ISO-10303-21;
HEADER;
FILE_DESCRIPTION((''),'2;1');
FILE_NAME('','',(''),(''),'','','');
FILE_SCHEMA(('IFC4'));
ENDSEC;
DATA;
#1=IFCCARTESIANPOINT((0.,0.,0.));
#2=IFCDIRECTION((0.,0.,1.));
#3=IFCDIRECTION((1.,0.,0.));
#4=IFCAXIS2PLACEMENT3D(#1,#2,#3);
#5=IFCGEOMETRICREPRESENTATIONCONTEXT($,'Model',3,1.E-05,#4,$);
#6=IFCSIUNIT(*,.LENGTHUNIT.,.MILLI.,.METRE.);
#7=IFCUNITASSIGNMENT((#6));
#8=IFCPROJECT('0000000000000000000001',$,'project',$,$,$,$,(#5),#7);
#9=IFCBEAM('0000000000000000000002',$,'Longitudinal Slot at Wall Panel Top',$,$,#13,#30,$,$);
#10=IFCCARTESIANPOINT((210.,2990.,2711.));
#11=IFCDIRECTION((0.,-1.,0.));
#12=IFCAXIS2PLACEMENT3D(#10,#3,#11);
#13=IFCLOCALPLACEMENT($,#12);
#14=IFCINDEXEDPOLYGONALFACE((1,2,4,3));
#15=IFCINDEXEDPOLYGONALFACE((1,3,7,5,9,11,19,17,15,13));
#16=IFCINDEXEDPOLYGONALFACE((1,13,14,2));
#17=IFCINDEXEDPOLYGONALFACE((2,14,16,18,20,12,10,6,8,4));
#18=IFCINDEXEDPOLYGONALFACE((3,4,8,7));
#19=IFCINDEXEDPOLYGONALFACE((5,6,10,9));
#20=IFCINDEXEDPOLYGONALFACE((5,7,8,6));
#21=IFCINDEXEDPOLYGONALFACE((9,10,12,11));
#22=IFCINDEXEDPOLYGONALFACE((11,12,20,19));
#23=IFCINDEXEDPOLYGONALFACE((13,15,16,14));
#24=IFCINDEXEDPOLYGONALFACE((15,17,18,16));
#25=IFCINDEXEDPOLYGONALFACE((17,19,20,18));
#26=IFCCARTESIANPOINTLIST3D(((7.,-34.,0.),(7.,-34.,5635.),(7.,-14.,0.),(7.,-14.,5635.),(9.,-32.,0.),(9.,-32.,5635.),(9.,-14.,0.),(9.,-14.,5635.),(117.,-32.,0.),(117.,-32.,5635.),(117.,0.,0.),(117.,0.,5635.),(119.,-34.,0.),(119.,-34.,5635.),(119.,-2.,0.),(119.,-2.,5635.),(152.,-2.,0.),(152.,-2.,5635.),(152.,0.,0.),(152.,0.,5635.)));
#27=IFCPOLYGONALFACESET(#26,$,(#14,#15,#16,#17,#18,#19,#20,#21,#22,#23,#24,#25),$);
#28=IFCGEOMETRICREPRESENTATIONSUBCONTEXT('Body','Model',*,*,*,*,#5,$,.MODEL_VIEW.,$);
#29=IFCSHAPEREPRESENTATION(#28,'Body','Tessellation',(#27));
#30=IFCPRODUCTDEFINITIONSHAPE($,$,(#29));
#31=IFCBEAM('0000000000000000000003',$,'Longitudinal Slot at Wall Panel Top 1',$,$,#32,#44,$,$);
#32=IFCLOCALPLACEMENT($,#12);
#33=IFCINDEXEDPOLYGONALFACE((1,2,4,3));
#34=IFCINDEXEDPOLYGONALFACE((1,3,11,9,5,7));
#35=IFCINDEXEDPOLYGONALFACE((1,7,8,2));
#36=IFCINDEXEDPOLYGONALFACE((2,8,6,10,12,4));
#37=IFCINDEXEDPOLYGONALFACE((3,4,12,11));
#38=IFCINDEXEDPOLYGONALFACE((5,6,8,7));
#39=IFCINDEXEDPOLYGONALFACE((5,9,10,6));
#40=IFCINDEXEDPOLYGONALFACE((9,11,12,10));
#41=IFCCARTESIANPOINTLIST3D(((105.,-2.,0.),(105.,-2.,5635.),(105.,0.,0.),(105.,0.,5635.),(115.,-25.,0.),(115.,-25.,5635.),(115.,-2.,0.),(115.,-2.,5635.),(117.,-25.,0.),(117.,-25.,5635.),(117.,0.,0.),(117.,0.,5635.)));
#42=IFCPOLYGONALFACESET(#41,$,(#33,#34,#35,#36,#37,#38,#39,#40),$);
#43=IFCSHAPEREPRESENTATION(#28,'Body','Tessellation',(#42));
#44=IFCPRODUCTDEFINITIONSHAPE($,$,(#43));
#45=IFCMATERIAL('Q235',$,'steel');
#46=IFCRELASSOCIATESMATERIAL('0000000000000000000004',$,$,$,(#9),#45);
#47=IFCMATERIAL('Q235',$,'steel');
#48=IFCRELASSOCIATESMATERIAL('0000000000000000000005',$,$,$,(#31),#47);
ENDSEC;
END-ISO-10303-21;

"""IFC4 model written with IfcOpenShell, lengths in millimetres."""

from ifc_helpers import new_model, si_unit, frame, origin_with_axes, place, context, subcontext, project, line, indexed_curve, outline, extrude, material, element, save


model = new_model("IFC4")

# Units and contexts
model_context = context("Model", 3, precision=1e-05, world=origin_with_axes())
body_context = subcontext(model_context, "Body", "Model", "MODEL_VIEW")
ifc_project = project(units=[si_unit("LENGTHUNIT", "METRE", prefix="MILLI")], contexts=[model_context])

# Beams
ifc_material_1 = material(Name="Q235", Category="steel")
beam_1_placement = place(None, frame((210.0, 2990.0, 2711.0), z_axis=(1.0, 0.0, 0.0), x_axis=(0.0, -1.0, 0.0)))
element("IfcBeam", 1, at=beam_1_placement, material=ifc_material_1, Name="Longitudinal Slot at Wall Panel Top", context=body_context, shape_type="SweptSolid", body=[
    extrude(outline(indexed_curve([(152.0, 0.0), (117.0, 0.0), (117.0, -32.0), (9.0, -32.0), (9.0, -14.0), (7.0, -14.0), (7.0, -34.0), (119.0, -34.0), (119.0, -2.0), (152.0, -2.0), (152.0, 0.0)], segments=[line(1, 2, 3, 4, 5, 6, 7, 8, 9, 10, 11, 1)])), origin_with_axes(), (0.0, 0.0, 1.0), 5635.0),
])
ifc_material_2 = material(Name="Q235", Category="steel")
beam_2_placement = place(None, frame((210.0, 2990.0, 2711.0), z_axis=(1.0, 0.0, 0.0), x_axis=(0.0, -1.0, 0.0)))
element("IfcBeam", 2, at=beam_2_placement, material=ifc_material_2, Name="Longitudinal Slot at Wall Panel Top 1", context=body_context, shape_type="SweptSolid", body=[
    extrude(outline(indexed_curve([(117.0, 0.0), (105.0, 0.0), (105.0, -2.0), (115.0, -2.0), (115.0, -25.0), (117.0, -25.0), (117.0, 0.0)], segments=[line(1, 2, 3, 4, 5, 6, 7, 1)])), origin_with_axes(), (0.0, 0.0, 1.0), 5635.0),
])

save(model, "model.ifc")
